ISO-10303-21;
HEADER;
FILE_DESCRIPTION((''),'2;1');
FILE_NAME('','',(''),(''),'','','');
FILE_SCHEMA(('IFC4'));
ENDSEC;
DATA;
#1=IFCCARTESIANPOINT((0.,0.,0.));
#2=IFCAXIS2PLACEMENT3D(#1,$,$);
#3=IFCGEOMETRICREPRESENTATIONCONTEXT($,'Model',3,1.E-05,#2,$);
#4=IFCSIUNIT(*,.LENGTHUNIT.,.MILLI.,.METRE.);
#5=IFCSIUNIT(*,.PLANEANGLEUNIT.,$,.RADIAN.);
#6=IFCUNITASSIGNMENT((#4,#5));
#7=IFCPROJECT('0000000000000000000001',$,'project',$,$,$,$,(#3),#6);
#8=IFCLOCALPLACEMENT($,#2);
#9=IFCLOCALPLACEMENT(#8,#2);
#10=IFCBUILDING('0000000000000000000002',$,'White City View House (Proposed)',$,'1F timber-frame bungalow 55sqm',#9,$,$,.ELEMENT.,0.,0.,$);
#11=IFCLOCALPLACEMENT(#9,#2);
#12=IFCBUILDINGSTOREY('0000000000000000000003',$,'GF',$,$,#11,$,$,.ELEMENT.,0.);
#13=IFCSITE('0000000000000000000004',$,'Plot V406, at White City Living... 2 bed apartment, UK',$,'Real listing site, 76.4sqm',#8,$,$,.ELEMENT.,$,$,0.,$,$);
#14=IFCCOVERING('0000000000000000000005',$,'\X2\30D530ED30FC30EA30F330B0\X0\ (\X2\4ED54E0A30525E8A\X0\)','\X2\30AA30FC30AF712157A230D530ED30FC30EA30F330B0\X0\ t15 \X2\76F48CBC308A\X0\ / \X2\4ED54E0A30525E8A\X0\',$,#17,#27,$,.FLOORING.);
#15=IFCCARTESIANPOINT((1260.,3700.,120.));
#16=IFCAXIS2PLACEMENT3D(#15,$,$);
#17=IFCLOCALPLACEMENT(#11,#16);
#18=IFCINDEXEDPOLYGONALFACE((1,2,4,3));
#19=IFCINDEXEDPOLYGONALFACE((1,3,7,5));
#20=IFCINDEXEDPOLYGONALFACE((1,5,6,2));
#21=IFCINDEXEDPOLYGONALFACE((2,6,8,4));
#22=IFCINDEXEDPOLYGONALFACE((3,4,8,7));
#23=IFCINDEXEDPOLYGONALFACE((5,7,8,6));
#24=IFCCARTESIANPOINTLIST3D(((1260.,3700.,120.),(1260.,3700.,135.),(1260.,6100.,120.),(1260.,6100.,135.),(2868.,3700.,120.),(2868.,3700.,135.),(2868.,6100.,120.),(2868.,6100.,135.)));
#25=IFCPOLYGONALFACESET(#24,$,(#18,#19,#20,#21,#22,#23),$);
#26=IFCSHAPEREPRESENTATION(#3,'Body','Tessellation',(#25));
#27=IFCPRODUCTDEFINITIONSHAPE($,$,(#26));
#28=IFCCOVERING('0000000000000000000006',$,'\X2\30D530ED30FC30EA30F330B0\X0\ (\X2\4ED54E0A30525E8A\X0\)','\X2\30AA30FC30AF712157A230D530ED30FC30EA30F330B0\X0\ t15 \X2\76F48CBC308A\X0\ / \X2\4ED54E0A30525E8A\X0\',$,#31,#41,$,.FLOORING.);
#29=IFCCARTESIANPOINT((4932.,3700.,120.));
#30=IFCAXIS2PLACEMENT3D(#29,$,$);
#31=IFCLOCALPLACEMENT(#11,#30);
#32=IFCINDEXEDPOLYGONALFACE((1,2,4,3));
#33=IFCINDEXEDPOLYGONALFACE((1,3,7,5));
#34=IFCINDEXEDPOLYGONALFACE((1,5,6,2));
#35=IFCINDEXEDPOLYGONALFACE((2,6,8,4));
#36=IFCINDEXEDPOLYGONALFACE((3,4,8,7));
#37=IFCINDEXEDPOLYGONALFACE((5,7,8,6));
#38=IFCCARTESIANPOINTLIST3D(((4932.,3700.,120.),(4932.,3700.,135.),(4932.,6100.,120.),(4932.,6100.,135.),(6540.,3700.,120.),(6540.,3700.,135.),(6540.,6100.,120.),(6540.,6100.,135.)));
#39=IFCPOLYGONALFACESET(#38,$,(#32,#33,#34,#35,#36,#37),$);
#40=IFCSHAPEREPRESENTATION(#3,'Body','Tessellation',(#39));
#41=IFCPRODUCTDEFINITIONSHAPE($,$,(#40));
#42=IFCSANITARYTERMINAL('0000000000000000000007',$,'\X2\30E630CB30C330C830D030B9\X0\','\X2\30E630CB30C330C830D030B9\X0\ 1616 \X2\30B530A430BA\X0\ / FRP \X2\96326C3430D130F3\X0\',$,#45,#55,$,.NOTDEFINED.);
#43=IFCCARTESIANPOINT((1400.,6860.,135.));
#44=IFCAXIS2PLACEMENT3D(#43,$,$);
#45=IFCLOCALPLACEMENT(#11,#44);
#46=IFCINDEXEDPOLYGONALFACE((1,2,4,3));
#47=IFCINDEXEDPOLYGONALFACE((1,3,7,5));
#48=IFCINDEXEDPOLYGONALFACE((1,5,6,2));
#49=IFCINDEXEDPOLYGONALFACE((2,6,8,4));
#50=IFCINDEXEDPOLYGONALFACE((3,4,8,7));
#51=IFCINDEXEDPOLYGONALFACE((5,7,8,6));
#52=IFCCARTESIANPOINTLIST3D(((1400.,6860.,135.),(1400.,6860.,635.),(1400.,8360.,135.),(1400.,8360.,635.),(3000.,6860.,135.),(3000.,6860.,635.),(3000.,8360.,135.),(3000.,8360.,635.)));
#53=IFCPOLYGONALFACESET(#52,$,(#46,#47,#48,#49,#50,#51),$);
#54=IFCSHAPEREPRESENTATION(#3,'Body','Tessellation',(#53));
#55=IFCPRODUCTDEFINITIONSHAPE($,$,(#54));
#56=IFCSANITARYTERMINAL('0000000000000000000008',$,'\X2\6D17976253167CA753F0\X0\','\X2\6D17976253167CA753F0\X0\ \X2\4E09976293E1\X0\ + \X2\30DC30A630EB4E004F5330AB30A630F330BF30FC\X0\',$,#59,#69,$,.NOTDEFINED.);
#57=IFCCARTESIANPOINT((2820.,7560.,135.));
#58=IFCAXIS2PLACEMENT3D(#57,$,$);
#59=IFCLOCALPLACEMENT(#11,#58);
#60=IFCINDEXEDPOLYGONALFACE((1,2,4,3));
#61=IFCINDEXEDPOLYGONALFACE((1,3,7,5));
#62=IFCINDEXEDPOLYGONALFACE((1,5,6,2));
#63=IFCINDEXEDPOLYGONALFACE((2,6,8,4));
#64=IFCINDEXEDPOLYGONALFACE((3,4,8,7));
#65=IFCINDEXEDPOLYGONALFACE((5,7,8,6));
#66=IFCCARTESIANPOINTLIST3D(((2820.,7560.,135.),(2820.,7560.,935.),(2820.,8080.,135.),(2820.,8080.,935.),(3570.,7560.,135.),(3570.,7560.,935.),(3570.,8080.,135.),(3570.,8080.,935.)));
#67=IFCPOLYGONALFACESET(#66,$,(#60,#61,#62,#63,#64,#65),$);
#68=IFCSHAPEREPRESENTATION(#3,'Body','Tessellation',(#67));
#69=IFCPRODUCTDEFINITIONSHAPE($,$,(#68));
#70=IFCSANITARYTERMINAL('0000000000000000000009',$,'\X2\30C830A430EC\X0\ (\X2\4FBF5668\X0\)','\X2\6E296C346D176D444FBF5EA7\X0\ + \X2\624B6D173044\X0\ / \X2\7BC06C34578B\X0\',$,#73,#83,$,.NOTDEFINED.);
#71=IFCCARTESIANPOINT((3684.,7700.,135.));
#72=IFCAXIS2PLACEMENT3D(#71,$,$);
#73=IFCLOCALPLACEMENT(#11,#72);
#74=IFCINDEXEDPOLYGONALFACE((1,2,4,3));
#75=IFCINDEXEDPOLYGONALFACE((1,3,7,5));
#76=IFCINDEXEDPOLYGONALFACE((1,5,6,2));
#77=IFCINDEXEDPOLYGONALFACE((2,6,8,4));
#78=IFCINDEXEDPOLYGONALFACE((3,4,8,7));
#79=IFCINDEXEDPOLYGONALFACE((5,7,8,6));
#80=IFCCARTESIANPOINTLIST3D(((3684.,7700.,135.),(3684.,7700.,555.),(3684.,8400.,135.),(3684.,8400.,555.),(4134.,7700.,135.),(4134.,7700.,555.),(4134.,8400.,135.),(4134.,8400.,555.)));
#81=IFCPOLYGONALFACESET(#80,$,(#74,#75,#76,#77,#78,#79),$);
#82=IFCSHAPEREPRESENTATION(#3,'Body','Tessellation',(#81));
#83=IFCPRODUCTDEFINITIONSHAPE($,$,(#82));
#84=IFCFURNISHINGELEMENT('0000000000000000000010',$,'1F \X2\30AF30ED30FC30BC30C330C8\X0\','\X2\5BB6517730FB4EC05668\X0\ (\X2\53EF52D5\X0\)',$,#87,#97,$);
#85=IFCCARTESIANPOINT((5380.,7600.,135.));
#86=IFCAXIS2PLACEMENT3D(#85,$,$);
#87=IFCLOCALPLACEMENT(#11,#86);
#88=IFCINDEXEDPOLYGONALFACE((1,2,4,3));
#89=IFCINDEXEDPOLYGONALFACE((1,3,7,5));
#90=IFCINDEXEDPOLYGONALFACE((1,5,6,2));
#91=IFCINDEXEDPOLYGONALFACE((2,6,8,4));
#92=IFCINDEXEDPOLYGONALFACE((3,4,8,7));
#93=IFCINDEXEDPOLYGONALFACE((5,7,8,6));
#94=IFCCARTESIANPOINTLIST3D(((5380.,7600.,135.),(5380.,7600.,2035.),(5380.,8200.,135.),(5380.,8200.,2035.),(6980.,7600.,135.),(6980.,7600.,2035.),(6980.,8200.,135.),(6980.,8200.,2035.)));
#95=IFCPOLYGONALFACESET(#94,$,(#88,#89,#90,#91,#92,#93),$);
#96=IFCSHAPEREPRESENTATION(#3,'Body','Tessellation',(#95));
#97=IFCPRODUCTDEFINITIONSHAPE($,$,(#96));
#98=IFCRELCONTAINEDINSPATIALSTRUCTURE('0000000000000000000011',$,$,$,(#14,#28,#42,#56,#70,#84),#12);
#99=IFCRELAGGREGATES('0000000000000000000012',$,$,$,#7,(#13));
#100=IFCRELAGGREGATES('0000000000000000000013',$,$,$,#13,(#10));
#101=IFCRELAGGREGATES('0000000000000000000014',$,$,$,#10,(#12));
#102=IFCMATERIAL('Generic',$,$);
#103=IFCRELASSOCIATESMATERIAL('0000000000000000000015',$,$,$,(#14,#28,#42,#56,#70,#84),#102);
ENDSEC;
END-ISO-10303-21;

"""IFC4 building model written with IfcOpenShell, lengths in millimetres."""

from ifc_helpers import new_model, si_unit, frame, frame_2d, origin, place, context, project, spatial, rectangle, extrude, material, element, save


model = new_model("IFC4")

# Units and contexts
model_context = context("Model", 3, precision=1e-05, world=origin())
ifc_project = project(units=[si_unit("LENGTHUNIT", "METRE", prefix="MILLI"), si_unit("PLANEANGLEUNIT", "RADIAN")], contexts=[model_context])

# Site, building, storey
site_placement = place(None, origin())
site = spatial("IfcSite", under=ifc_project, at=site_placement, Name="Plot V406, at White City Living... 2 bed apartment, UK", ObjectType="Real listing site, 76.4sqm", CompositionType="ELEMENT", RefElevation=0.0)
building_placement = place(site_placement, origin())
building = spatial("IfcBuilding", under=site, at=building_placement, Name="White City View House (Proposed)", ObjectType="1F timber-frame bungalow 55sqm", CompositionType="ELEMENT", ElevationOfRefHeight=0.0, ElevationOfTerrain=0.0)
storey_placement = place(building_placement, origin())
storey = spatial("IfcBuildingStorey", under=building, at=storey_placement, Name="GF", CompositionType="ELEMENT", Elevation=0.0)

# Coverings
ifc_material_1 = material(Name="Generic")
covering_1_placement = place(storey_placement, frame((1260.0, 3700.0, 120.0)))
element("IfcCovering", 1, at=covering_1_placement, inside=storey, material=ifc_material_1, Name="フローリング (仕上げ床)", Description="オーク無垢フローリング t15 直貼り / 仕上げ床", PredefinedType="FLOORING", context=model_context, shape_type="SweptSolid", body=[
    extrude(rectangle(XDim=1608.0, YDim=2400.0, at=frame_2d((804.0, 1200.0))), frame((1260.0, 3700.0, 120.0)), (0.0, 0.0, 1.0), 15.0),
])
covering_2_placement = place(storey_placement, frame((4932.0, 3700.0, 120.0)))
element("IfcCovering", 2, at=covering_2_placement, inside=storey, material=ifc_material_1, Name="フローリング (仕上げ床)", Description="オーク無垢フローリング t15 直貼り / 仕上げ床", PredefinedType="FLOORING", context=model_context, shape_type="SweptSolid", body=[
    extrude(rectangle(XDim=1608.0, YDim=2400.0, at=frame_2d((804.0, 1200.0))), frame((4932.0, 3700.0, 120.0)), (0.0, 0.0, 1.0), 15.0),
])

# Sanitary terminals
sanitary_terminal_1_placement = place(storey_placement, frame((1400.0, 6860.0, 135.0)))
element("IfcSanitaryTerminal", 3, at=sanitary_terminal_1_placement, inside=storey, material=ifc_material_1, Name="ユニットバス", Description="ユニットバス 1616 サイズ / FRP 防水パン", PredefinedType="NOTDEFINED", context=model_context, shape_type="SweptSolid", body=[
    extrude(rectangle(XDim=1600.0, YDim=1500.0, at=frame_2d((800.0, 750.0))), frame((1400.0, 6860.0, 135.0)), (0.0, 0.0, 1.0), 500.0),
])
sanitary_terminal_2_placement = place(storey_placement, frame((2820.0, 7560.0, 135.0)))
element("IfcSanitaryTerminal", 4, at=sanitary_terminal_2_placement, inside=storey, material=ifc_material_1, Name="洗面化粧台", Description="洗面化粧台 三面鏡 + ボウル一体カウンター", PredefinedType="NOTDEFINED", context=model_context, shape_type="SweptSolid", body=[
    extrude(rectangle(XDim=750.0, YDim=520.0, at=frame_2d((375.0, 260.0))), frame((2820.0, 7560.0, 135.0)), (0.0, 0.0, 1.0), 800.0),
])
sanitary_terminal_3_placement = place(storey_placement, frame((3684.0, 7700.0, 135.0)))
element("IfcSanitaryTerminal", 5, at=sanitary_terminal_3_placement, inside=storey, material=ifc_material_1, Name="トイレ (便器)", Description="温水洗浄便座 + 手洗い / 節水型", PredefinedType="NOTDEFINED", context=model_context, shape_type="SweptSolid", body=[
    extrude(rectangle(XDim=450.0, YDim=700.0, at=frame_2d((225.0, 350.0))), frame((3684.0, 7700.0, 135.0)), (0.0, 0.0, 1.0), 420.0),
])

# Furnishing element
furnishing_placement = place(storey_placement, frame((5380.0, 7600.0, 135.0)))
element("IfcFurnishingElement", 6, at=furnishing_placement, inside=storey, material=ifc_material_1, Name="1F クローゼット", Description="家具・什器 (可動)", context=model_context, shape_type="SweptSolid", body=[
    extrude(rectangle(XDim=1600.0, YDim=600.0, at=frame_2d((800.0, 300.0))), frame((5380.0, 7600.0, 135.0)), (0.0, 0.0, 1.0), 1900.0),
])

save(model, "model.ifc")
